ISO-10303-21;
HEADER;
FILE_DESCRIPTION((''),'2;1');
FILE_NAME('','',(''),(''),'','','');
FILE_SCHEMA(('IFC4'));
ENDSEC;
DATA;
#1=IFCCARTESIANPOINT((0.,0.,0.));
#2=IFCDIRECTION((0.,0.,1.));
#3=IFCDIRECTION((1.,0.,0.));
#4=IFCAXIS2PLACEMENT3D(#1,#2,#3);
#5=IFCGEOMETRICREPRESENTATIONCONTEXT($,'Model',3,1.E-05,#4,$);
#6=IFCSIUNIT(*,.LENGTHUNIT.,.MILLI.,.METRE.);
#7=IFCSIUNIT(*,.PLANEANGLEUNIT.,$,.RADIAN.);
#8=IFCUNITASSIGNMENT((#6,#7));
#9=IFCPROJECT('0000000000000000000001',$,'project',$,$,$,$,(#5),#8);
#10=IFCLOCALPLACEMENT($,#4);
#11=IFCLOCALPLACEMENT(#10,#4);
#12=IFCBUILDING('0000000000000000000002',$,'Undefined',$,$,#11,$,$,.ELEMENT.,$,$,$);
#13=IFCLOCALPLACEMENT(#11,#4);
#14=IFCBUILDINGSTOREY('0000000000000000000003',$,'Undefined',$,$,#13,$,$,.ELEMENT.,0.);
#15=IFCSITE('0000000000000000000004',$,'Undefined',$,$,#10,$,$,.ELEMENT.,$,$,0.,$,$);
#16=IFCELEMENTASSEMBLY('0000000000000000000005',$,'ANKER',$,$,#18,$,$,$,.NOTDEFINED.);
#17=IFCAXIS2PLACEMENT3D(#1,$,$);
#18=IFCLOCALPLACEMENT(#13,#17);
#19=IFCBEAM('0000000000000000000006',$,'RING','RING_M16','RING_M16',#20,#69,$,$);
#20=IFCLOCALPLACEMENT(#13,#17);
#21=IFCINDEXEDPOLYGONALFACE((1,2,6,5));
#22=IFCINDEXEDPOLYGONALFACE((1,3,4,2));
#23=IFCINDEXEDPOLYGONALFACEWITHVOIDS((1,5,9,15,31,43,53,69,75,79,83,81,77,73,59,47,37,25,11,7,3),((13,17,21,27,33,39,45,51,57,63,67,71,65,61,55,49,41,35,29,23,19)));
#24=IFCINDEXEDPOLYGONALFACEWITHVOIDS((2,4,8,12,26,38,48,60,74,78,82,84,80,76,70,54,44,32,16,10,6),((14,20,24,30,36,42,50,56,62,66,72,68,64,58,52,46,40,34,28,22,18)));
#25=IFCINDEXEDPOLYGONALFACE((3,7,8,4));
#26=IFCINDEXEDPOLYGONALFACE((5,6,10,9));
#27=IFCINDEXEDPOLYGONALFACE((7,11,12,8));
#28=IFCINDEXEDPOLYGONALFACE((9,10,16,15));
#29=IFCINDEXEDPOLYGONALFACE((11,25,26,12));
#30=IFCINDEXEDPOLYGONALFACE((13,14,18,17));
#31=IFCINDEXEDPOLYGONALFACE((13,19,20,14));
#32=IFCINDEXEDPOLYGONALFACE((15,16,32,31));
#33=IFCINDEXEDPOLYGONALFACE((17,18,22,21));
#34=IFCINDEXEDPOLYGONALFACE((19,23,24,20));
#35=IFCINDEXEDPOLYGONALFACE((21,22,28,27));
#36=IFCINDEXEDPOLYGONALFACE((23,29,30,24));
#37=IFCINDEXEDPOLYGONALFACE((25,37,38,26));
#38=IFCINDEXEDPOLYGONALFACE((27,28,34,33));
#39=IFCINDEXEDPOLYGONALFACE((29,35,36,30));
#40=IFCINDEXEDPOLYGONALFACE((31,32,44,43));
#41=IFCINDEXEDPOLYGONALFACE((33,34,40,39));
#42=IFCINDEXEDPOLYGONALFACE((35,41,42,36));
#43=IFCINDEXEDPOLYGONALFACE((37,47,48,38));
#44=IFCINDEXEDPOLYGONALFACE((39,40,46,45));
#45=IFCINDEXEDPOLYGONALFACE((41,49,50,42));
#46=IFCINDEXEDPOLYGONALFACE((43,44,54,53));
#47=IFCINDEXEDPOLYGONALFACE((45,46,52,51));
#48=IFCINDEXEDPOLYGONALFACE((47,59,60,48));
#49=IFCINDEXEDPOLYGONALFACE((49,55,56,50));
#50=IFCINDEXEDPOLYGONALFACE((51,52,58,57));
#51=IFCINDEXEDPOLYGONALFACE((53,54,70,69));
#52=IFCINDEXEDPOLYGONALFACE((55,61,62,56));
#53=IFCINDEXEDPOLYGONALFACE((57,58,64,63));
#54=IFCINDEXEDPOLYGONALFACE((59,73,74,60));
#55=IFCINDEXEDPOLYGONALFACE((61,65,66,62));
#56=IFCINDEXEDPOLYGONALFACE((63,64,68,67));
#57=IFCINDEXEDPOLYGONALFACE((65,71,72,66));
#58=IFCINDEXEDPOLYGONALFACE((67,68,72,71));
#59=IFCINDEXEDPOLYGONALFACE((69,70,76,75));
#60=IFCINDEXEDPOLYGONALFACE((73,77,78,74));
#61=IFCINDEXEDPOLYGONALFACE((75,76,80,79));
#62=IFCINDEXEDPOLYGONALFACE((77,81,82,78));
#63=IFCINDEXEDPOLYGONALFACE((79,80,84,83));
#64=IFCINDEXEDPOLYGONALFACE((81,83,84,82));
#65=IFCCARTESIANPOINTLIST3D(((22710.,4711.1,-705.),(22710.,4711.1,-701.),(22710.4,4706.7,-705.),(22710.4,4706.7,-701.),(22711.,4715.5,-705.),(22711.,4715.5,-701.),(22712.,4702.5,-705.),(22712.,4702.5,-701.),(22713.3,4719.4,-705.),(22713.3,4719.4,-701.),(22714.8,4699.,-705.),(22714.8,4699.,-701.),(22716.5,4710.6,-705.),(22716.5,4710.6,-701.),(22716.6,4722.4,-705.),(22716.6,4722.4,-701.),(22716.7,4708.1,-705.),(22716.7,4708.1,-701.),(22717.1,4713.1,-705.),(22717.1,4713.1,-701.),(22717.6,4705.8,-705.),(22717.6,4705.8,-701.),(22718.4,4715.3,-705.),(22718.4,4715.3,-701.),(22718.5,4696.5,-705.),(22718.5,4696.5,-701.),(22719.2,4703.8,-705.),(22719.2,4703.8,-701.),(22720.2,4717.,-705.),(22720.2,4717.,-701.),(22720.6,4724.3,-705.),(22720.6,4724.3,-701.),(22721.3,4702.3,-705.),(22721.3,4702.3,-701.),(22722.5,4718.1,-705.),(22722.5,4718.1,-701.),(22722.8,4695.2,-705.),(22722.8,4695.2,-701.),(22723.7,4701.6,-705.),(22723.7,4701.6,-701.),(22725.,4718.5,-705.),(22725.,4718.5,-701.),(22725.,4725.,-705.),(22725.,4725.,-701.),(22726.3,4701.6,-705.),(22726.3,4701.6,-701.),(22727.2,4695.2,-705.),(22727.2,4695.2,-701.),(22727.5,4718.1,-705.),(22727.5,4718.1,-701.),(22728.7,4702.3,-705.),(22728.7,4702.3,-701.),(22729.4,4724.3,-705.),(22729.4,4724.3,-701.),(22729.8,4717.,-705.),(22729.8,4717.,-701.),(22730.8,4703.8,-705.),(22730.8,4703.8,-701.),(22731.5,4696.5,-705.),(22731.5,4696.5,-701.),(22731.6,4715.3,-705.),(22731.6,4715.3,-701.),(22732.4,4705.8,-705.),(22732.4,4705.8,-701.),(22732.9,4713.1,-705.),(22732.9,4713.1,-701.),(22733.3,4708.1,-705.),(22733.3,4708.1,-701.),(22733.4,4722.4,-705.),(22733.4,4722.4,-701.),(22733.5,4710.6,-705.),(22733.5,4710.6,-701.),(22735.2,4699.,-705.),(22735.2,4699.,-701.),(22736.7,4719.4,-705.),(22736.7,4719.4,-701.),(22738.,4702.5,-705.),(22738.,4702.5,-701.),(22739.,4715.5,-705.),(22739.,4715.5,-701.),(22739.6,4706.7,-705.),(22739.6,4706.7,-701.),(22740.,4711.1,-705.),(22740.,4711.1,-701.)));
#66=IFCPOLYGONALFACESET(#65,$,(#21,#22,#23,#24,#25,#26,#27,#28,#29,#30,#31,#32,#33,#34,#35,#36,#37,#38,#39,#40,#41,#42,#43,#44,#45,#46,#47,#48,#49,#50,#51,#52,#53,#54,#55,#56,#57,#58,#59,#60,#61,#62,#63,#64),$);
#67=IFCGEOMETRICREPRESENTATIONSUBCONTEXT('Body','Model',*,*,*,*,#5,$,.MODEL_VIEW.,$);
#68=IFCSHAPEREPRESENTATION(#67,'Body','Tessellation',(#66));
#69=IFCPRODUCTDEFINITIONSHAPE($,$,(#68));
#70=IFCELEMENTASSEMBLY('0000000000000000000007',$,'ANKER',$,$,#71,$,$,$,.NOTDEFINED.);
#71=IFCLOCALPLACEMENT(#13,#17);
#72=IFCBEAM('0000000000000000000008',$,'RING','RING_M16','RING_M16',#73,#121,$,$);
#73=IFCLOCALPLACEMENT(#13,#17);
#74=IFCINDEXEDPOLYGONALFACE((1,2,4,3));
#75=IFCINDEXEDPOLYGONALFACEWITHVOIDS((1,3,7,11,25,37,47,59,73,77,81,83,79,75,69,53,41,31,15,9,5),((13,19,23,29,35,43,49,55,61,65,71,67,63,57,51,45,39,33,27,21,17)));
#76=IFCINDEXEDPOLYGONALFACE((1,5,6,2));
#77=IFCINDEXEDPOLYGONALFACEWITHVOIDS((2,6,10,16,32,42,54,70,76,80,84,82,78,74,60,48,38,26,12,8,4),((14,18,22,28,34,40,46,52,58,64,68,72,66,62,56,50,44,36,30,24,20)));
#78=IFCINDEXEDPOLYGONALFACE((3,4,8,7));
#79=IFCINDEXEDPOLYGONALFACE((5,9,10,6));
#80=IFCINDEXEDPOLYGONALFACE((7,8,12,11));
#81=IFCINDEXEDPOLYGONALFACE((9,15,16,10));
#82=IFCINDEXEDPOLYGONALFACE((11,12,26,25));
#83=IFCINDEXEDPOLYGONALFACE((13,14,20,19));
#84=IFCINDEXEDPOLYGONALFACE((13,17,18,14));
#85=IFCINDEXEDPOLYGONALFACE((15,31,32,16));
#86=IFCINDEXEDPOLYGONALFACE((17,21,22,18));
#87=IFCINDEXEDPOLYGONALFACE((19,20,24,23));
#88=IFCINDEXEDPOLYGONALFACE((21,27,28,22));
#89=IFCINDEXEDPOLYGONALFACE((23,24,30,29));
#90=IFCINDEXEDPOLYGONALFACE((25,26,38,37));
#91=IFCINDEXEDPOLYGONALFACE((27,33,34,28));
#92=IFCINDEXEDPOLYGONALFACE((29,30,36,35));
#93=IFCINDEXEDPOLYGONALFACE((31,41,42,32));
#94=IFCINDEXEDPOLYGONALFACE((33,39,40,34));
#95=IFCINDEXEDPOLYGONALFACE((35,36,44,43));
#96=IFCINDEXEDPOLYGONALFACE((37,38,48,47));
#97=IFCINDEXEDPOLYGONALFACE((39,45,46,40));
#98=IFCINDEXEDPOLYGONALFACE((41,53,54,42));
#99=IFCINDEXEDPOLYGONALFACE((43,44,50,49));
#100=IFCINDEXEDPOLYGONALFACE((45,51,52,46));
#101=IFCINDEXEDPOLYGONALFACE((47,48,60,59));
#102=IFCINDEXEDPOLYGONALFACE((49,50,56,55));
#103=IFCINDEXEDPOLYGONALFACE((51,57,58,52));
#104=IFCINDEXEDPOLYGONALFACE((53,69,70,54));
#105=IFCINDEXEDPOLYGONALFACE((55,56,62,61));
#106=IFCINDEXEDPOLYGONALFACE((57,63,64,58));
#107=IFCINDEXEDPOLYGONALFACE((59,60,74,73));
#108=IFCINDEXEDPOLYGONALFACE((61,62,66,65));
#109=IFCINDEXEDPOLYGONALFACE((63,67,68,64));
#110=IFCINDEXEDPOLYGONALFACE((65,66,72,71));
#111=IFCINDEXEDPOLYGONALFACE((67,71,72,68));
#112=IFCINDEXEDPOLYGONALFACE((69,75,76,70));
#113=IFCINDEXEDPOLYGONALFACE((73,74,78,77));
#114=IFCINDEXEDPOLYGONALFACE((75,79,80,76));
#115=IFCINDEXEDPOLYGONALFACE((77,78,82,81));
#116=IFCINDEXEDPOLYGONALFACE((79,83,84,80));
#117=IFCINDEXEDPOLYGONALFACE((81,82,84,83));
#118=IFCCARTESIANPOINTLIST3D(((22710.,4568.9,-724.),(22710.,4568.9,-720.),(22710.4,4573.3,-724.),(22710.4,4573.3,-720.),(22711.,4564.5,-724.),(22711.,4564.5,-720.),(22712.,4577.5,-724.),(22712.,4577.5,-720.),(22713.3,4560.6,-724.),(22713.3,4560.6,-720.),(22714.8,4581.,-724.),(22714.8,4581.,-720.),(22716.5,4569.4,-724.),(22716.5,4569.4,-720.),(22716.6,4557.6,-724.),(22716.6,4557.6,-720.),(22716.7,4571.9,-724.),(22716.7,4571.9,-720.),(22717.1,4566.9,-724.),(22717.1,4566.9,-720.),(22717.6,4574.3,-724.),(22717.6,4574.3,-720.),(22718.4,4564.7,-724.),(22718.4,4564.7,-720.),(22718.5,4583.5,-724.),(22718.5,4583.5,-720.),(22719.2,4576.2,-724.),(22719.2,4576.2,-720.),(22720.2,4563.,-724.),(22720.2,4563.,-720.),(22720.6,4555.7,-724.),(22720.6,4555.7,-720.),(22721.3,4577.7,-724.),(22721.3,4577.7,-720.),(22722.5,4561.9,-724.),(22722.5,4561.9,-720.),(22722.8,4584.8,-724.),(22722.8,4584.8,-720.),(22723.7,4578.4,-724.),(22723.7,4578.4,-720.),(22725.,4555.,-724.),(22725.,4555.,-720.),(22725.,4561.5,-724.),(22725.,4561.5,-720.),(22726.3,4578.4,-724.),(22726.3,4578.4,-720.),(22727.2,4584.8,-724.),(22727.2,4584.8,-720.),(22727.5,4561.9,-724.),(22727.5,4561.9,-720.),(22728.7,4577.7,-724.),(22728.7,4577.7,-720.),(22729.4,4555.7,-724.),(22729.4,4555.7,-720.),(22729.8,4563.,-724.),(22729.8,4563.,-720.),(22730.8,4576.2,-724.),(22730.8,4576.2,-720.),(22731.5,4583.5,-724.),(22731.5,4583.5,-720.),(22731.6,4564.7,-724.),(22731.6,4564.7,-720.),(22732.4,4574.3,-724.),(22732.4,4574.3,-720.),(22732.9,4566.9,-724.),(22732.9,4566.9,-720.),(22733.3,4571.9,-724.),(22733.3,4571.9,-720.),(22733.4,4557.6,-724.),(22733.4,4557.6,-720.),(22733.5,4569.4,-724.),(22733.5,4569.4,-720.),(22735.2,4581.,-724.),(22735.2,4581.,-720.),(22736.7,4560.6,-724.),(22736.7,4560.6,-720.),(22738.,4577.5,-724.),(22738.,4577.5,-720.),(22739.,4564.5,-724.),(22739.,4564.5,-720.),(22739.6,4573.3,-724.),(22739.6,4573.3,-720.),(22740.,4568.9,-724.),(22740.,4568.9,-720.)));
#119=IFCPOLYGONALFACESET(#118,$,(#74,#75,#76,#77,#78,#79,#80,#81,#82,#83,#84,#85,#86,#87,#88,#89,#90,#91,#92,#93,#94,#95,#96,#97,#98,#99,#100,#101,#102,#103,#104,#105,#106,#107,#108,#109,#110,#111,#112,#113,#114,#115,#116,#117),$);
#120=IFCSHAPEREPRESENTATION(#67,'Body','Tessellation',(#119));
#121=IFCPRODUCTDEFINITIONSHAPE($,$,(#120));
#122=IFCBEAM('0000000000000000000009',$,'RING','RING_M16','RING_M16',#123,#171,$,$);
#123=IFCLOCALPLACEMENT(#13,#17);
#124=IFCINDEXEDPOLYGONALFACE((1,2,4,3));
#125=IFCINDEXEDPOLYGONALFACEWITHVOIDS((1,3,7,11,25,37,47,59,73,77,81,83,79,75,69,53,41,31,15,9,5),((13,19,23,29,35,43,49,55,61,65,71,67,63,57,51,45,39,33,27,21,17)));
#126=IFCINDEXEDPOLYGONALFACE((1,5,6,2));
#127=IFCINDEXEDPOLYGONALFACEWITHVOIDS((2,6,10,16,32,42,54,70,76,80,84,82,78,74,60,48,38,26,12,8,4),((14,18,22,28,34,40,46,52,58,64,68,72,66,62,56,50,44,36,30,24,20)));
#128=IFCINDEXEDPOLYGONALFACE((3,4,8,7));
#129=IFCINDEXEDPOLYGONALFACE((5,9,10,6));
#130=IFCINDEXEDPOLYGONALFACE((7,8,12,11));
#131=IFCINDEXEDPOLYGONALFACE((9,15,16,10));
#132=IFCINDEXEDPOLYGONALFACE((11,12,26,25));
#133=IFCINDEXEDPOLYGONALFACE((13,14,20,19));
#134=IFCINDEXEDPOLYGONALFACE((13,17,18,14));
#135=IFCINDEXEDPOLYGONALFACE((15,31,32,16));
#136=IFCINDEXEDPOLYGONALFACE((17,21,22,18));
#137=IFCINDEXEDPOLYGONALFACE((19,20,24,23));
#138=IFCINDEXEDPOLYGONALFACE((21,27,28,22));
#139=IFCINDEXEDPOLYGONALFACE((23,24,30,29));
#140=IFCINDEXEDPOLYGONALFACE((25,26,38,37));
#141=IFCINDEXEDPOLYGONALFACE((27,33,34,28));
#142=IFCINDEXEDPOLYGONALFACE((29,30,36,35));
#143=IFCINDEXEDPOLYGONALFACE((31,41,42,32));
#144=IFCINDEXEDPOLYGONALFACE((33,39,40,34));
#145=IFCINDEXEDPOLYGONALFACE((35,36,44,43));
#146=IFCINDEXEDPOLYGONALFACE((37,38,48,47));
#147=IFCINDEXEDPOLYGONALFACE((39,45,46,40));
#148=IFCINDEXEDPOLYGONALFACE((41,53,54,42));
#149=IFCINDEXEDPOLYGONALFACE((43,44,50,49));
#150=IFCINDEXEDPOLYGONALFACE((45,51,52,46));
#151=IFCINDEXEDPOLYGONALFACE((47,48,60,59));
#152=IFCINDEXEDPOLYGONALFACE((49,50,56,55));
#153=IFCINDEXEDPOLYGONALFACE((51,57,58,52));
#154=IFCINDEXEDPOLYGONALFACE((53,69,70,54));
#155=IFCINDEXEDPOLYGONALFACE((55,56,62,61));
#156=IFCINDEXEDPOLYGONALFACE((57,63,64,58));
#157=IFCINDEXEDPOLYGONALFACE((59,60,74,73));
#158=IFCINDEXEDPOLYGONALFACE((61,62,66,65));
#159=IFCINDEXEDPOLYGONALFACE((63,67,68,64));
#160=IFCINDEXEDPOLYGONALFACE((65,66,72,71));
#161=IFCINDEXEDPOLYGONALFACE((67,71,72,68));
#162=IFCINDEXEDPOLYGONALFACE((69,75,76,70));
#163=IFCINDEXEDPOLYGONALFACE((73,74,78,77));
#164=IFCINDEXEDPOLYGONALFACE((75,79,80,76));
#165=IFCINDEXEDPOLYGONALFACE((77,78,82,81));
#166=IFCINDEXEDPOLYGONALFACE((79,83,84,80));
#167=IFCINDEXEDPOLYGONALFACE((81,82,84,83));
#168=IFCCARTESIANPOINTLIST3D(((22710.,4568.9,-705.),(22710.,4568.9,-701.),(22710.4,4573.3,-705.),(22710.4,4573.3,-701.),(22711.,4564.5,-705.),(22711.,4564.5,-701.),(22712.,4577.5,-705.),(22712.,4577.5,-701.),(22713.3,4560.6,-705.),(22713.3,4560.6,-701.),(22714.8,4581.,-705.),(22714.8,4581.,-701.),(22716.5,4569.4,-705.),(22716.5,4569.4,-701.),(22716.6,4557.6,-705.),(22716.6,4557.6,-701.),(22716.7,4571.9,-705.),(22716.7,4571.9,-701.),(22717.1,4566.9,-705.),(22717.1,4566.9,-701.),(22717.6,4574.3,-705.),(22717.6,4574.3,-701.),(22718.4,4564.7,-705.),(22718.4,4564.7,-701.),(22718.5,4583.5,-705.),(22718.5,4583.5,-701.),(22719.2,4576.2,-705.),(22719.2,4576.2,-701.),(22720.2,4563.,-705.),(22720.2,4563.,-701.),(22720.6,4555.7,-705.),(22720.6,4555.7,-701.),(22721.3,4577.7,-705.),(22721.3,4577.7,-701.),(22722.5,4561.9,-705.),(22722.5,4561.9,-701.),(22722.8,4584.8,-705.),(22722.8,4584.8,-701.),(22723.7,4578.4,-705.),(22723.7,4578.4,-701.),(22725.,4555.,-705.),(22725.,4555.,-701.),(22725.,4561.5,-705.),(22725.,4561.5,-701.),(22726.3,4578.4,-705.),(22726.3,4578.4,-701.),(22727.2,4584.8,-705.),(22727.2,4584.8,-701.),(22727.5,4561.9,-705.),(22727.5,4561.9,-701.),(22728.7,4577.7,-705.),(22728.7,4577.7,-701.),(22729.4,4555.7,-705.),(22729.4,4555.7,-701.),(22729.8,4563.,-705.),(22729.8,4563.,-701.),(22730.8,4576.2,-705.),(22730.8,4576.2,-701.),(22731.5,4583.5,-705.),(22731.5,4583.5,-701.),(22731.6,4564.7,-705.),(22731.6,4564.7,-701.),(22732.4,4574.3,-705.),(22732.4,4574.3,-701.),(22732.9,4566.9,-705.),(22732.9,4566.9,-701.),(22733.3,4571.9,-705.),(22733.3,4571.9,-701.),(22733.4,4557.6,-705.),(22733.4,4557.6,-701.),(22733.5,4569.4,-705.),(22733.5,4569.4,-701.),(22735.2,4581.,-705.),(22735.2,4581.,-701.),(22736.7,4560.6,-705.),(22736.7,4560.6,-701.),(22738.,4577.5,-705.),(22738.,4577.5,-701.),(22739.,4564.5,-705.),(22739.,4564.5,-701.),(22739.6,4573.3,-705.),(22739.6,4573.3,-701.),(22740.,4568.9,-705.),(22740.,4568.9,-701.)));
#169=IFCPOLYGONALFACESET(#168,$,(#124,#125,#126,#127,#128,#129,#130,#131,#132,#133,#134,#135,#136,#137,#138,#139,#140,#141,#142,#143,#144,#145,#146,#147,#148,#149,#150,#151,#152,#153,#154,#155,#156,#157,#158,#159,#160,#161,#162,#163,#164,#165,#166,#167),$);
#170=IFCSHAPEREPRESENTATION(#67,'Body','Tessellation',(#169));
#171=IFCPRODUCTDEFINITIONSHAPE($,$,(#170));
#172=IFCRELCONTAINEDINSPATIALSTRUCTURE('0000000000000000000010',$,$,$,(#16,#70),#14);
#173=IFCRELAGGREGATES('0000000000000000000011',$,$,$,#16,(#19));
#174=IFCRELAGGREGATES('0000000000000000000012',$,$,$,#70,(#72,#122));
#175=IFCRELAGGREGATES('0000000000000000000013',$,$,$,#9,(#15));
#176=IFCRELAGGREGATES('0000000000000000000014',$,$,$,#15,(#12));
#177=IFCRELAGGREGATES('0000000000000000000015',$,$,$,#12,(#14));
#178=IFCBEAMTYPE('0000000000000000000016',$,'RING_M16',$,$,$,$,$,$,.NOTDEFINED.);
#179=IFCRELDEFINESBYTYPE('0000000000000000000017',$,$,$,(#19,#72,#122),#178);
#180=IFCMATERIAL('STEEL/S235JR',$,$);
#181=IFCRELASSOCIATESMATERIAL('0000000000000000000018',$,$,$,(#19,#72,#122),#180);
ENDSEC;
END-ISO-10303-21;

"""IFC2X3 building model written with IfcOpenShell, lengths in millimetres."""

from ifc_helpers import new_model, si_unit, frame, origin_with_axes, origin_2d_with_axis, place, context, subcontext, project, spatial, hollow_circle, extrude, material, type_object, element, aggregate, save


model = new_model("IFC2X3")

# Units and contexts
model_context = context("Model", 3, precision=1e-05, world=origin_with_axes())
body_context = subcontext(model_context, "Body", "Model", "MODEL_VIEW")
ifc_project = project(units=[si_unit("LENGTHUNIT", "METRE", prefix="MILLI"), si_unit("PLANEANGLEUNIT", "RADIAN")], contexts=[model_context])

# Site, building, storey
site_placement = place(None, origin_with_axes())
site = spatial("IfcSite", under=ifc_project, at=site_placement, Name="Undefined", CompositionType="ELEMENT", RefElevation=0.0)
building_placement = place(site_placement, origin_with_axes())
building = spatial("IfcBuilding", under=site, at=building_placement, Name="Undefined", CompositionType="ELEMENT")
storey_placement = place(building_placement, origin_with_axes())
storey = spatial("IfcBuildingStorey", under=building, at=storey_placement, Name="Undefined", CompositionType="ELEMENT", Elevation=0.0)

# Shared definitions
ifc_material = material(Name="STEEL/S235JR")

# Element assemblies, beams
beam_type_1 = type_object("IfcBeamType", Name="RING_M16", PredefinedType="NOTDEFINED")
assembly_1_placement = place(storey_placement, frame((22725.0, 4710.0, -655.0), z_axis=(-1.0, 0.0, 0.0), x_axis=(0.0, 0.0, -1.0)))
assembly_1 = element("IfcElementAssembly", 1, at=assembly_1_placement, inside=storey, Name="ANKER", PredefinedType="NOTDEFINED")
beam_1_placement = place(storey_placement, frame((22725.0, 4710.0, -701.0), z_axis=(-1.0, 0.0, 0.0), x_axis=(0.0, 0.0, -1.0)))
beam_1 = element("IfcBeam", 2, at=beam_1_placement, type_object=beam_type_1, material=ifc_material, Name="RING", Description="RING_M16", ObjectType="RING_M16", context=body_context, shape_type="SweptSolid", body=[
    extrude(hollow_circle(Radius=15.0, WallThickness=6.5, at=origin_2d_with_axis()), frame((4.0, 0.0, 0.0), z_axis=(-1.0, 0.0, 0.0), x_axis=(0.0, -1.0, 0.0)), (0.0, 0.0, 1.0), 4.0),
])
aggregate(assembly_1, [beam_1])
assembly_2_placement = place(storey_placement, frame((22725.0, 4570.0, -655.0), z_axis=(1.0, 0.0, 0.0), x_axis=(0.0, 0.0, -1.0)))
assembly_2 = element("IfcElementAssembly", 3, at=assembly_2_placement, inside=storey, Name="ANKER", PredefinedType="NOTDEFINED")
beam_2_placement = place(storey_placement, frame((22725.0, 4570.0, -720.0), z_axis=(1.0, 0.0, 0.0), x_axis=(0.0, 0.0, -1.0)))
beam_2 = element("IfcBeam", 4, at=beam_2_placement, type_object=beam_type_1, material=ifc_material, Name="RING", Description="RING_M16", ObjectType="RING_M16", context=body_context, shape_type="SweptSolid", body=[
    extrude(hollow_circle(Radius=15.0, WallThickness=6.5, at=origin_2d_with_axis()), frame((4.0, 0.0, 0.0), z_axis=(-1.0, 0.0, 0.0), x_axis=(0.0, -1.0, 0.0)), (0.0, 0.0, 1.0), 4.0),
])
beam_3_placement = place(storey_placement, frame((22725.0, 4570.0, -701.0), z_axis=(1.0, 0.0, 0.0), x_axis=(0.0, 0.0, -1.0)))
beam_3 = element("IfcBeam", 5, at=beam_3_placement, type_object=beam_type_1, material=ifc_material, Name="RING", Description="RING_M16", ObjectType="RING_M16", context=body_context, shape_type="SweptSolid", body=[
    extrude(hollow_circle(Radius=15.0, WallThickness=6.5, at=origin_2d_with_axis()), frame((4.0, 0.0, 0.0), z_axis=(-1.0, 0.0, 0.0), x_axis=(0.0, -1.0, 0.0)), (0.0, 0.0, 1.0), 4.0),
])
aggregate(assembly_2, [beam_2, beam_3])

save(model, "model.ifc")
